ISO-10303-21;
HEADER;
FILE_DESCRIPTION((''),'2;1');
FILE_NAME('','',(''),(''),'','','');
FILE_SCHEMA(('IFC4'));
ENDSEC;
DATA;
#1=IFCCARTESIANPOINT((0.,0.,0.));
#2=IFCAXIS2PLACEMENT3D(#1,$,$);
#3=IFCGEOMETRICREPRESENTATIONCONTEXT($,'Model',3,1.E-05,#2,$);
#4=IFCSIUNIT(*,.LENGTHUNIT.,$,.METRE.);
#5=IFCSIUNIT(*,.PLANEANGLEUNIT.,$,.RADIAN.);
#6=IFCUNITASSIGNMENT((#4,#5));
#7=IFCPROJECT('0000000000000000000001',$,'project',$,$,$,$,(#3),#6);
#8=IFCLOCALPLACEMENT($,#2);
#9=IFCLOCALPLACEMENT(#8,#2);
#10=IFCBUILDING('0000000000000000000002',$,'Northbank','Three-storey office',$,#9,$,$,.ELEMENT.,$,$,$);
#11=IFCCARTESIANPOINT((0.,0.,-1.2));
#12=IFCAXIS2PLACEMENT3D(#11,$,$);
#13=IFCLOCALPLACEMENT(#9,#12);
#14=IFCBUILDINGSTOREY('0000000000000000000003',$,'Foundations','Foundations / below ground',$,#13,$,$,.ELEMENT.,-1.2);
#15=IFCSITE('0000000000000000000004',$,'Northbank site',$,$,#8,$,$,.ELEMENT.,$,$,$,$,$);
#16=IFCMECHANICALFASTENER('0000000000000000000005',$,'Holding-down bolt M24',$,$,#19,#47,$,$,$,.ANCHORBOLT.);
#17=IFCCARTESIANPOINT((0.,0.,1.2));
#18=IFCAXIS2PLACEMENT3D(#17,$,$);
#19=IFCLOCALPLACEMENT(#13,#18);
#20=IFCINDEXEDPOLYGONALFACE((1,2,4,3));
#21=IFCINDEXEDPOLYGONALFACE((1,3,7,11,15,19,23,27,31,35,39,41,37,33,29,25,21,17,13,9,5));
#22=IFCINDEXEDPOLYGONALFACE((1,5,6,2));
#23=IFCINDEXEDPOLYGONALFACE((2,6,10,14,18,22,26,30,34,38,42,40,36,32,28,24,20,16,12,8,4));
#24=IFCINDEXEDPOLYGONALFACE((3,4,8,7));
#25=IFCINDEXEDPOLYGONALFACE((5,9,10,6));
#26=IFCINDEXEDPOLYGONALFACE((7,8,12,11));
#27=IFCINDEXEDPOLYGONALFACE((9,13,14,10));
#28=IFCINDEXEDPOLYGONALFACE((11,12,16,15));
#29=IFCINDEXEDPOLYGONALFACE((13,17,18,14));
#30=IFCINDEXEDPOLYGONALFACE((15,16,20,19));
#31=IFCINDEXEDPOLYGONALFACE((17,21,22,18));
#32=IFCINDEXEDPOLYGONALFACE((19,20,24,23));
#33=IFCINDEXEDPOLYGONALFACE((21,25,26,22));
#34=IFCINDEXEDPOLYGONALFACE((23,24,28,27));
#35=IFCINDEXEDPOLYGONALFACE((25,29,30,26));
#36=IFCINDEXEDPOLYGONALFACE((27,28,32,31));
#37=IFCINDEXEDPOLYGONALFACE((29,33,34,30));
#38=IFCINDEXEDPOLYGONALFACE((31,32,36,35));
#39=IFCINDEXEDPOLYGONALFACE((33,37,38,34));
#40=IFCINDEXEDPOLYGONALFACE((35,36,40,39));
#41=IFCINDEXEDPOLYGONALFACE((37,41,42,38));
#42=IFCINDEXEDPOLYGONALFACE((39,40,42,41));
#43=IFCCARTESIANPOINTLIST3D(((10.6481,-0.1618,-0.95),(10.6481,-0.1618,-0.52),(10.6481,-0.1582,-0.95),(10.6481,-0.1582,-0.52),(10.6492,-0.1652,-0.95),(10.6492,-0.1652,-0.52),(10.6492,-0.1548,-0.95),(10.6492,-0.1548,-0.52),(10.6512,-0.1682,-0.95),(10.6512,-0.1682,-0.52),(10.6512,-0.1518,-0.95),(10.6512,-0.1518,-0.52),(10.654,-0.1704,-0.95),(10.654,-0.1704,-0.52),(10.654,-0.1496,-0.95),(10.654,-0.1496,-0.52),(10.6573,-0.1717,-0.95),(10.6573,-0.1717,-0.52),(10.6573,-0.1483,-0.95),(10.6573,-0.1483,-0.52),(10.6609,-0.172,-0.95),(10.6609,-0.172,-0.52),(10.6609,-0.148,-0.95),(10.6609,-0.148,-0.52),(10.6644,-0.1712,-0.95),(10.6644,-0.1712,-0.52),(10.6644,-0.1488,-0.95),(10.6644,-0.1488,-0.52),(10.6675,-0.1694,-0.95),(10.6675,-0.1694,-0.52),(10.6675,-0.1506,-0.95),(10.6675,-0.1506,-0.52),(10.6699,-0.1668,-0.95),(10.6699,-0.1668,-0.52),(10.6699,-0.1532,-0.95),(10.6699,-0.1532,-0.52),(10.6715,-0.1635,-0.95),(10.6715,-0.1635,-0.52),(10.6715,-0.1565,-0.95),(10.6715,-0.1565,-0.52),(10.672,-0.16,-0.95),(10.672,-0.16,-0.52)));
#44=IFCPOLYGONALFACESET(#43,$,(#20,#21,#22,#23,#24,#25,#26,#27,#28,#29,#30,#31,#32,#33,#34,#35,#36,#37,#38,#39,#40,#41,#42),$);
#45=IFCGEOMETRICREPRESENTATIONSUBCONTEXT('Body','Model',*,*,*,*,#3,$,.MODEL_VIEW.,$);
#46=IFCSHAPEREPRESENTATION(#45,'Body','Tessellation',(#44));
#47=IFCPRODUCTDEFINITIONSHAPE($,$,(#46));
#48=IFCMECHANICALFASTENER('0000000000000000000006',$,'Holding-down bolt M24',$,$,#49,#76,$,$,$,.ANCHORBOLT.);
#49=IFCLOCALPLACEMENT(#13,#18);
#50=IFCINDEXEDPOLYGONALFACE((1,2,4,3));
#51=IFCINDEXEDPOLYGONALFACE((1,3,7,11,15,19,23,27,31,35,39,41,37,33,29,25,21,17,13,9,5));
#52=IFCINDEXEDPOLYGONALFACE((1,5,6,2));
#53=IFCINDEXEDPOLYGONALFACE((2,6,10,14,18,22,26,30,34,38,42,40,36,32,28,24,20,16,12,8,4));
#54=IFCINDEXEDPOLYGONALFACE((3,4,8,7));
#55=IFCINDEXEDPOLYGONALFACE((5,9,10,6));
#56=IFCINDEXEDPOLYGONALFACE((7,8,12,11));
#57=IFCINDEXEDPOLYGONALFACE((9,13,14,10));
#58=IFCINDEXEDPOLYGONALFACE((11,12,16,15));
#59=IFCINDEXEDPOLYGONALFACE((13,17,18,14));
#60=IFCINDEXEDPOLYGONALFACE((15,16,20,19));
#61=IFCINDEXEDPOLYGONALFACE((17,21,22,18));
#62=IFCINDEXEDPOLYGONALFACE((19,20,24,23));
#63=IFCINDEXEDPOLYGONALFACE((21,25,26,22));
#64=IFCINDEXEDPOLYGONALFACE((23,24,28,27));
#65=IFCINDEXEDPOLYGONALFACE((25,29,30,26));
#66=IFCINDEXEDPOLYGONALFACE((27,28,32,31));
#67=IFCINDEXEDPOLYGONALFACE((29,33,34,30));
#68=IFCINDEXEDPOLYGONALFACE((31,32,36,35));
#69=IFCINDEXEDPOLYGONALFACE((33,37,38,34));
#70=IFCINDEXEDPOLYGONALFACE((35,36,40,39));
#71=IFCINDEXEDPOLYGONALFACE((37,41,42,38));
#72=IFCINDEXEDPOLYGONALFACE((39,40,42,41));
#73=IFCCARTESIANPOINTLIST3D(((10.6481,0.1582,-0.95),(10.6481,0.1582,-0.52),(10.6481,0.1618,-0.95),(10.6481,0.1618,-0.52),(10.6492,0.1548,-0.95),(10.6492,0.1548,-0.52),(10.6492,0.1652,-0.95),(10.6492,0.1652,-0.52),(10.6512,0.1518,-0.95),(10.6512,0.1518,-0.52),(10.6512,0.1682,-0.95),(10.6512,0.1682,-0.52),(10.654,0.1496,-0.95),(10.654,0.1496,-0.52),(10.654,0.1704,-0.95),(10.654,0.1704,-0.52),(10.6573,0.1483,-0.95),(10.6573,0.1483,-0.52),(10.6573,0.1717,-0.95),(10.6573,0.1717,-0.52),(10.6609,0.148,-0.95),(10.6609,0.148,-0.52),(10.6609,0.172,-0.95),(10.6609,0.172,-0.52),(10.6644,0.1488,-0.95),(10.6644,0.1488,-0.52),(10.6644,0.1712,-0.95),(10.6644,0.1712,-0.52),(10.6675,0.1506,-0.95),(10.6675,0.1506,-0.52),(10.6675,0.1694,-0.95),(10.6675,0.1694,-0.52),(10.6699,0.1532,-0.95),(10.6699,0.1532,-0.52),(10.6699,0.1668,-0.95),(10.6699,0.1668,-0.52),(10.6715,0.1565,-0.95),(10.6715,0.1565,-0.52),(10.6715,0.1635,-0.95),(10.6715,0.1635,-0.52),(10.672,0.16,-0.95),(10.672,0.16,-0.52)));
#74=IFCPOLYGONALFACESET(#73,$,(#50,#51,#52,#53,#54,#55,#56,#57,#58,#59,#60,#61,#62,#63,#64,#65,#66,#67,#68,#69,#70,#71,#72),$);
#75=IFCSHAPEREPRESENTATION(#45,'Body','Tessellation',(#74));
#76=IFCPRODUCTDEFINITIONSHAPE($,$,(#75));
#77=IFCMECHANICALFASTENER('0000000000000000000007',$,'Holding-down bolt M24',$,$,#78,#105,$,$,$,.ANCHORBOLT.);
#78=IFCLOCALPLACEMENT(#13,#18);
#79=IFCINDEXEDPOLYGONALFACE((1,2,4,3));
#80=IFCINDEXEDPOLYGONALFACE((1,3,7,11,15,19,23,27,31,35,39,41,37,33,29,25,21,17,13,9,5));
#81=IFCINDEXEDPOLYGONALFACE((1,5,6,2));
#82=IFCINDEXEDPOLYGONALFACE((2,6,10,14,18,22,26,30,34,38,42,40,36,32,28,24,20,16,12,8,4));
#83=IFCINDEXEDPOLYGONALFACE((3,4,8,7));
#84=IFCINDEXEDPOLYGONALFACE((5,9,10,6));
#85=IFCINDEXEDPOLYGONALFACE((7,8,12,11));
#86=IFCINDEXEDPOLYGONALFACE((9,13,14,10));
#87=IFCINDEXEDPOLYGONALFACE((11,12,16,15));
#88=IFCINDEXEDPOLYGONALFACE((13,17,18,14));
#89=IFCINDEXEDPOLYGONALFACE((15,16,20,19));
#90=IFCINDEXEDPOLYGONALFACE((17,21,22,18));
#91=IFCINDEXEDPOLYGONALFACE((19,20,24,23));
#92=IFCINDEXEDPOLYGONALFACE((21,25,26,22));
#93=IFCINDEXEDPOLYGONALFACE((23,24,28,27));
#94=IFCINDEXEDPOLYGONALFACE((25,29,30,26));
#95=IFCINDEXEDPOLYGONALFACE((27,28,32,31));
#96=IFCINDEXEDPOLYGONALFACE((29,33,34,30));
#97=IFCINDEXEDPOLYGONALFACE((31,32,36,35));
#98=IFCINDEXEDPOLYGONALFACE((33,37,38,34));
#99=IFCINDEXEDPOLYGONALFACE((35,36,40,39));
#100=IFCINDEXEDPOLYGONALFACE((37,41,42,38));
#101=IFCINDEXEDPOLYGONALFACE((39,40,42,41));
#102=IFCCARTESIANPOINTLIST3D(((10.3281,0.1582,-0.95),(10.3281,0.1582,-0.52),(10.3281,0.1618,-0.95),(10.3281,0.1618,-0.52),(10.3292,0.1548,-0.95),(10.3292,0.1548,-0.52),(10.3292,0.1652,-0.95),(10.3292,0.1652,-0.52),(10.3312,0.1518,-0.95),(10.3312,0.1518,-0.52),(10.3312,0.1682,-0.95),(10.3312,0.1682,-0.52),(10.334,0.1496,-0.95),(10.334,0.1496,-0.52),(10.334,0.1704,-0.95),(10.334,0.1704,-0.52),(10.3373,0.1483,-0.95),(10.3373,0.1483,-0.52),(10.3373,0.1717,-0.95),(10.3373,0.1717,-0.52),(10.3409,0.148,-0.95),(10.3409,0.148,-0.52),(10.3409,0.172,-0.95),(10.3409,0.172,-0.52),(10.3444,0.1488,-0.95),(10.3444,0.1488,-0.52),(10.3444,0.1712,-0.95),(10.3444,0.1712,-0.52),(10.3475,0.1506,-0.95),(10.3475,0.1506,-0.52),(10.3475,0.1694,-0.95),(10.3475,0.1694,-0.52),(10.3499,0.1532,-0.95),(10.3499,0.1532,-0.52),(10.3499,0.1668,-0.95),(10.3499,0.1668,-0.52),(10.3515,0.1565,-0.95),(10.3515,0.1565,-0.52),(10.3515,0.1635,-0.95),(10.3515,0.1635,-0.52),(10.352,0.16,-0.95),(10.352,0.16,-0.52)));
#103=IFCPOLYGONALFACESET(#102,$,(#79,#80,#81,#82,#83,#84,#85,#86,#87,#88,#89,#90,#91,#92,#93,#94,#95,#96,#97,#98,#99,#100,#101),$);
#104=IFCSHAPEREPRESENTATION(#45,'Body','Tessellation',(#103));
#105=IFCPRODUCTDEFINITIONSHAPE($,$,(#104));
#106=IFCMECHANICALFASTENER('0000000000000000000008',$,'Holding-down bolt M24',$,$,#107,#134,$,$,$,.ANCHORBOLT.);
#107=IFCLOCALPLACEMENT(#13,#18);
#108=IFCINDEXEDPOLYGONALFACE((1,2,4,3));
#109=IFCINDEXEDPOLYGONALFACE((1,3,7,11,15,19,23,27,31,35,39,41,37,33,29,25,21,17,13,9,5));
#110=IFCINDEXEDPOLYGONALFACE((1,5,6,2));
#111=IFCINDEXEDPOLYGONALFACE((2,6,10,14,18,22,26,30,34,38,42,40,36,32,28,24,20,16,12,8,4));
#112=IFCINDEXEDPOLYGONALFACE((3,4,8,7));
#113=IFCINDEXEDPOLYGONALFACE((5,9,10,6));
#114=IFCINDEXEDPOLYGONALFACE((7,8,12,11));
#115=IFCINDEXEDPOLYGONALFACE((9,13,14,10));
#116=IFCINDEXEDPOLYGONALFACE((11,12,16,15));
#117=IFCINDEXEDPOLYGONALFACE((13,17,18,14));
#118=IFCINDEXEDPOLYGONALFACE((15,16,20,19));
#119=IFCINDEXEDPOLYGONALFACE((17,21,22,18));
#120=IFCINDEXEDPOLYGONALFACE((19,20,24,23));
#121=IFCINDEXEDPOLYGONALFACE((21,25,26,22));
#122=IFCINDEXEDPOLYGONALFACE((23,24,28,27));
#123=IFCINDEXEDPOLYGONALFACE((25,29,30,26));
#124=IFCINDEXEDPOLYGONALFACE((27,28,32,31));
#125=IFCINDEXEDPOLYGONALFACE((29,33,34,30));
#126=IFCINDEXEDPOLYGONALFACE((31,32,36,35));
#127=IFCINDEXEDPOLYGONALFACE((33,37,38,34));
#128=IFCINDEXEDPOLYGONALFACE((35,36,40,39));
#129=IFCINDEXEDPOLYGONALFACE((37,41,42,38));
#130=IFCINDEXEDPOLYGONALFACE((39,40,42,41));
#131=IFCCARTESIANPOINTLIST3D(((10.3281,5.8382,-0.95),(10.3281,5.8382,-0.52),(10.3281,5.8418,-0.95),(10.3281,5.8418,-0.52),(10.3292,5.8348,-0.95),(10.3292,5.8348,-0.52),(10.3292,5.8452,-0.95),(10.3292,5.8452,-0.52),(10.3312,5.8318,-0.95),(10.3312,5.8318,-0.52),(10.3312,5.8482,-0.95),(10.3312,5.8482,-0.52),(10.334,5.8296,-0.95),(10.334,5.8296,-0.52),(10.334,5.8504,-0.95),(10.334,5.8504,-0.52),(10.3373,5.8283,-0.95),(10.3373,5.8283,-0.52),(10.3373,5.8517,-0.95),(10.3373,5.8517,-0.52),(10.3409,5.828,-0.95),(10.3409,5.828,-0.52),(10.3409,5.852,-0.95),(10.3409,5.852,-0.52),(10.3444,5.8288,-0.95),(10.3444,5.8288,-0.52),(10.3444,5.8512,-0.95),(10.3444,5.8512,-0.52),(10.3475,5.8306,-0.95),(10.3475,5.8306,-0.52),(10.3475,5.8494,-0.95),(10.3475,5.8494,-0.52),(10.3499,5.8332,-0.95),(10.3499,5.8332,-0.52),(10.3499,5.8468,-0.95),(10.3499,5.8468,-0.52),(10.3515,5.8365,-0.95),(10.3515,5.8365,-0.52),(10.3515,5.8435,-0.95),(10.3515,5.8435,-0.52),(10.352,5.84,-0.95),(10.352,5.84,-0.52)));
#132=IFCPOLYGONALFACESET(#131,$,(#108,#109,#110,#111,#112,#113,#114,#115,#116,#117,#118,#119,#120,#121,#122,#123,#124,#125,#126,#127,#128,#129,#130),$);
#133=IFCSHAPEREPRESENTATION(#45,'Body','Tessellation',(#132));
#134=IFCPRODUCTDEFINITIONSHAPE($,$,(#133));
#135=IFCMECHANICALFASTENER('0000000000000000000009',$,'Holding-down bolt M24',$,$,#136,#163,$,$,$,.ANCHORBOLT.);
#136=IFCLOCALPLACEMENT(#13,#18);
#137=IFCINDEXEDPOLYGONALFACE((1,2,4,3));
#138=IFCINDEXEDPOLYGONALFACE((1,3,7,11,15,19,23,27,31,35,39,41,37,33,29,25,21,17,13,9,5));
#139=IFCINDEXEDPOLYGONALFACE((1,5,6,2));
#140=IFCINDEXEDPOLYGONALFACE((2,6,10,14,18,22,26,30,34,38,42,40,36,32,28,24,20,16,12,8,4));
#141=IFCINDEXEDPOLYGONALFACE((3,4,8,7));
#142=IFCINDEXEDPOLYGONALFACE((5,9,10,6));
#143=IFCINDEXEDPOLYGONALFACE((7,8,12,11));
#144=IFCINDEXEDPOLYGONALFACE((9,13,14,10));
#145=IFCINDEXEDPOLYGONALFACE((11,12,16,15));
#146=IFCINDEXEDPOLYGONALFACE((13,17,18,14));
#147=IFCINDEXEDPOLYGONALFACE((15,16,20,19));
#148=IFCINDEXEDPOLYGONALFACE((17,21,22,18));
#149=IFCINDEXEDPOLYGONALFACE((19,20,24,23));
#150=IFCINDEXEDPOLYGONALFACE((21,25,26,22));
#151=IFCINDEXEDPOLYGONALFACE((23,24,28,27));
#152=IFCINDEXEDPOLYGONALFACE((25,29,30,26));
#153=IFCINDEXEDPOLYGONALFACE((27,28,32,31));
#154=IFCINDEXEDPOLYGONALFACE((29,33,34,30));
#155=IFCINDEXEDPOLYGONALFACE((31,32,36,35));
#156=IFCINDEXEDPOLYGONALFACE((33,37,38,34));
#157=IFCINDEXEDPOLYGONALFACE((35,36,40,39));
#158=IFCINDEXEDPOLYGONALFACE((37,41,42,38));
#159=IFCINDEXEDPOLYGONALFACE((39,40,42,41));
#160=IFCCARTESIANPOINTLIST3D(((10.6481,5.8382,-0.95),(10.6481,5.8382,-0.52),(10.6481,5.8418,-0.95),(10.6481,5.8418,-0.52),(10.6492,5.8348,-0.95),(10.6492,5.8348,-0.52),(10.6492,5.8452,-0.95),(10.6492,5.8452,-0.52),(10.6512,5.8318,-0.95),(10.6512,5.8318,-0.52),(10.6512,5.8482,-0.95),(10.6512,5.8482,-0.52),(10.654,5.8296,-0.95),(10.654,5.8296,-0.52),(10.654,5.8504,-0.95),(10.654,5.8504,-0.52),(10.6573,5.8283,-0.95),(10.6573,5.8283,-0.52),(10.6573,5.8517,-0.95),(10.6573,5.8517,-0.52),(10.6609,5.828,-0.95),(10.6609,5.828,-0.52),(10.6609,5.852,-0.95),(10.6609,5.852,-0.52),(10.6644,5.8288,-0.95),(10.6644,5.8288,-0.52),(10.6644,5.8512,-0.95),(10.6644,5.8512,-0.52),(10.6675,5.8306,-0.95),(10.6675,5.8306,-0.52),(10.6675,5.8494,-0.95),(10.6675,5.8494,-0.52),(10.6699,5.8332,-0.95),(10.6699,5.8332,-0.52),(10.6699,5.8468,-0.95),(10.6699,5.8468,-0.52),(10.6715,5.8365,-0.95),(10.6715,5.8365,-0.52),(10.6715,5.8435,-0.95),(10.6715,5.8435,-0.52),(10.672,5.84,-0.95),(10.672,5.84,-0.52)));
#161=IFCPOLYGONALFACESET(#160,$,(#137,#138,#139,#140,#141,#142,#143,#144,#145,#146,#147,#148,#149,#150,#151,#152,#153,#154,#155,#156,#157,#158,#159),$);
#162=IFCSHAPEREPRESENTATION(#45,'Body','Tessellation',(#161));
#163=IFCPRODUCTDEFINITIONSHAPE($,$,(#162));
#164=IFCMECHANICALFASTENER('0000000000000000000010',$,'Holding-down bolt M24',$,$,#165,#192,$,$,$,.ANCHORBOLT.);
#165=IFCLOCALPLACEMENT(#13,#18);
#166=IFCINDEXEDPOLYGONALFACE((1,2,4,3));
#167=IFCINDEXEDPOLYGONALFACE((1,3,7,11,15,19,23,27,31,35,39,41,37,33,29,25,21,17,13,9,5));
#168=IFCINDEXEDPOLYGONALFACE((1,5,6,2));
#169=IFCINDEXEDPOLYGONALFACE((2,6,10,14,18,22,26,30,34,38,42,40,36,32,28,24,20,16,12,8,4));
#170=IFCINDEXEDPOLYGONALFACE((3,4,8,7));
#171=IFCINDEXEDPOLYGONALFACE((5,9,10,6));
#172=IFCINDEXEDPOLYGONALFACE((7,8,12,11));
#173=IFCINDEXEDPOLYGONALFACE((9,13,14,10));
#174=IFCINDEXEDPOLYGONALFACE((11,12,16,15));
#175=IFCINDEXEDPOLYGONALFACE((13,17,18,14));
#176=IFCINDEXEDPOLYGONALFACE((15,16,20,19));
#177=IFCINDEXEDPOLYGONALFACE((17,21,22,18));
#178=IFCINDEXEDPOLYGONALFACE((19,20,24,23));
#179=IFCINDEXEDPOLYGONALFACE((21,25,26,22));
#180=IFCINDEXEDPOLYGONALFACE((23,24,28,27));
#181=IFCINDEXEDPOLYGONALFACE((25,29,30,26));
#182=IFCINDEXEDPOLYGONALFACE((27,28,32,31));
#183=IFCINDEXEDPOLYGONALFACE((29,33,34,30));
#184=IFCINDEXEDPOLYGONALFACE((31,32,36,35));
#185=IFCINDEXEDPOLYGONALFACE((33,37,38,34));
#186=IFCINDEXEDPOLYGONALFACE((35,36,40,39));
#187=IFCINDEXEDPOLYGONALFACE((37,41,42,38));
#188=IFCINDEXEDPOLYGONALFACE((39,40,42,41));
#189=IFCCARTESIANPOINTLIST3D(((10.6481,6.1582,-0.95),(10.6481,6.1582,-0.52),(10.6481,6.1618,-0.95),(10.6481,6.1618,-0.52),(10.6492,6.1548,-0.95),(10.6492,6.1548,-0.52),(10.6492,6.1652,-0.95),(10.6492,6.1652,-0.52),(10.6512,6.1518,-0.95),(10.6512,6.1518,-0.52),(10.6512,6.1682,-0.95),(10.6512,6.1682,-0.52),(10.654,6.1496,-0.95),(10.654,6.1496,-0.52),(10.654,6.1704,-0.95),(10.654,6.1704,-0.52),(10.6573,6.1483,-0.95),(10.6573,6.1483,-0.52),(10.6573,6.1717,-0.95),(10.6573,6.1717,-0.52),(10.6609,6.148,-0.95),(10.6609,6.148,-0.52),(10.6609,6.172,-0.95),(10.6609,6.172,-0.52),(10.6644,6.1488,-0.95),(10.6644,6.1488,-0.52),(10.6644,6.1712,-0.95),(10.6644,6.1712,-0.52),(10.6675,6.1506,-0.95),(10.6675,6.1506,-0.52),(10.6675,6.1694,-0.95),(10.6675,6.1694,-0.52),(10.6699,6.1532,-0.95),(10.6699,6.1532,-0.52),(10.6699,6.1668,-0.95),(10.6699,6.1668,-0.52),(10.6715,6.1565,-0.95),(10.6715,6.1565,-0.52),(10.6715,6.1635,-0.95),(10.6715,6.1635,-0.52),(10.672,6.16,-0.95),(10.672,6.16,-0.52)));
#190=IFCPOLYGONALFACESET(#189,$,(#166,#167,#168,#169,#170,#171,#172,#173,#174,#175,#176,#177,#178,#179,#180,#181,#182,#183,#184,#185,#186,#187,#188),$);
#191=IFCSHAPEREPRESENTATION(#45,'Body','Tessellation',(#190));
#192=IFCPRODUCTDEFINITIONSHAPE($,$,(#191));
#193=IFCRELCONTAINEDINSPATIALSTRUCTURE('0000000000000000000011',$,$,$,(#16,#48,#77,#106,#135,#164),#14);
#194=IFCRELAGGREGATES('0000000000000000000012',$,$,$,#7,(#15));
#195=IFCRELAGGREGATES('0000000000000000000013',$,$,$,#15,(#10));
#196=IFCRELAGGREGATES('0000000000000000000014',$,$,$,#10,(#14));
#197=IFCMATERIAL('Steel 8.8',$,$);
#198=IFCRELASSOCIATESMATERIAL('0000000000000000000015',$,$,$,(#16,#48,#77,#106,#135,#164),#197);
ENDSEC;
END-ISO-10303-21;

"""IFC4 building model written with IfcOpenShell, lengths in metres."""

from ifc_helpers import new_model, si_unit, frame, origin, place, context, subcontext, project, spatial, circle, extrude, material, element, save


model = new_model("IFC4")

# Units and contexts
model_context = context("Model", 3, precision=1e-05, world=origin())
body_context = subcontext(model_context, "Body", "Model", "MODEL_VIEW")
ifc_project = project(units=[si_unit("LENGTHUNIT", "METRE"), si_unit("PLANEANGLEUNIT", "RADIAN")], contexts=[model_context])

# Site, building, storey
site_placement = place(None, origin())
site = spatial("IfcSite", under=ifc_project, at=site_placement, Name="Northbank site", CompositionType="ELEMENT")
building_placement = place(site_placement, origin())
building = spatial("IfcBuilding", under=site, at=building_placement, Name="Northbank", Description="Three-storey office", CompositionType="ELEMENT")
storey_placement = place(building_placement, frame((0.0, 0.0, -1.2)))
storey = spatial("IfcBuildingStorey", under=building, at=storey_placement, Name="Foundations", Description="Foundations / below ground", CompositionType="ELEMENT", Elevation=-1.2)

# Mechanical fasteners
ifc_material_1 = material(Name="Steel 8.8")
mechanical_fastener_1_placement = place(storey_placement, frame((0.0, 0.0, 1.2)))
element("IfcMechanicalFastener", 1, at=mechanical_fastener_1_placement, inside=storey, material=ifc_material_1, Name="Holding-down bolt M24", PredefinedType="ANCHORBOLT", context=body_context, shape_type="SweptSolid", body=[
    extrude(circle(Radius=0.012), frame((10.66, -0.16, -0.95), z_axis=(0.0, 0.0, 1.0), x_axis=(1.0, 0.0, 0.0)), (0.0, 0.0, 1.0), 0.43),
])
mechanical_fastener_2_placement = place(storey_placement, frame((0.0, 0.0, 1.2)))
element("IfcMechanicalFastener", 2, at=mechanical_fastener_2_placement, inside=storey, material=ifc_material_1, Name="Holding-down bolt M24", PredefinedType="ANCHORBOLT", context=body_context, shape_type="SweptSolid", body=[
    extrude(circle(Radius=0.012), frame((10.66, 0.16, -0.95), z_axis=(0.0, 0.0, 1.0), x_axis=(1.0, 0.0, 0.0)), (0.0, 0.0, 1.0), 0.43),
])
mechanical_fastener_3_placement = place(storey_placement, frame((0.0, 0.0, 1.2)))
element("IfcMechanicalFastener", 3, at=mechanical_fastener_3_placement, inside=storey, material=ifc_material_1, Name="Holding-down bolt M24", PredefinedType="ANCHORBOLT", context=body_context, shape_type="SweptSolid", body=[
    extrude(circle(Radius=0.012), frame((10.34, 0.16, -0.95), z_axis=(0.0, 0.0, 1.0), x_axis=(1.0, 0.0, 0.0)), (0.0, 0.0, 1.0), 0.43),
])
mechanical_fastener_4_placement = place(storey_placement, frame((0.0, 0.0, 1.2)))
element("IfcMechanicalFastener", 4, at=mechanical_fastener_4_placement, inside=storey, material=ifc_material_1, Name="Holding-down bolt M24", PredefinedType="ANCHORBOLT", context=body_context, shape_type="SweptSolid", body=[
    extrude(circle(Radius=0.012), frame((10.34, 5.84, -0.95), z_axis=(0.0, 0.0, 1.0), x_axis=(1.0, 0.0, 0.0)), (0.0, 0.0, 1.0), 0.43),
])
mechanical_fastener_5_placement = place(storey_placement, frame((0.0, 0.0, 1.2)))
element("IfcMechanicalFastener", 5, at=mechanical_fastener_5_placement, inside=storey, material=ifc_material_1, Name="Holding-down bolt M24", PredefinedType="ANCHORBOLT", context=body_context, shape_type="SweptSolid", body=[
    extrude(circle(Radius=0.012), frame((10.66, 5.84, -0.95), z_axis=(0.0, 0.0, 1.0), x_axis=(1.0, 0.0, 0.0)), (0.0, 0.0, 1.0), 0.43),
])
mechanical_fastener_6_placement = place(storey_placement, frame((0.0, 0.0, 1.2)))
element("IfcMechanicalFastener", 6, at=mechanical_fastener_6_placement, inside=storey, material=ifc_material_1, Name="Holding-down bolt M24", PredefinedType="ANCHORBOLT", context=body_context, shape_type="SweptSolid", body=[
    extrude(circle(Radius=0.012), frame((10.66, 6.16, -0.95), z_axis=(0.0, 0.0, 1.0), x_axis=(1.0, 0.0, 0.0)), (0.0, 0.0, 1.0), 0.43),
])

save(model, "model.ifc")
